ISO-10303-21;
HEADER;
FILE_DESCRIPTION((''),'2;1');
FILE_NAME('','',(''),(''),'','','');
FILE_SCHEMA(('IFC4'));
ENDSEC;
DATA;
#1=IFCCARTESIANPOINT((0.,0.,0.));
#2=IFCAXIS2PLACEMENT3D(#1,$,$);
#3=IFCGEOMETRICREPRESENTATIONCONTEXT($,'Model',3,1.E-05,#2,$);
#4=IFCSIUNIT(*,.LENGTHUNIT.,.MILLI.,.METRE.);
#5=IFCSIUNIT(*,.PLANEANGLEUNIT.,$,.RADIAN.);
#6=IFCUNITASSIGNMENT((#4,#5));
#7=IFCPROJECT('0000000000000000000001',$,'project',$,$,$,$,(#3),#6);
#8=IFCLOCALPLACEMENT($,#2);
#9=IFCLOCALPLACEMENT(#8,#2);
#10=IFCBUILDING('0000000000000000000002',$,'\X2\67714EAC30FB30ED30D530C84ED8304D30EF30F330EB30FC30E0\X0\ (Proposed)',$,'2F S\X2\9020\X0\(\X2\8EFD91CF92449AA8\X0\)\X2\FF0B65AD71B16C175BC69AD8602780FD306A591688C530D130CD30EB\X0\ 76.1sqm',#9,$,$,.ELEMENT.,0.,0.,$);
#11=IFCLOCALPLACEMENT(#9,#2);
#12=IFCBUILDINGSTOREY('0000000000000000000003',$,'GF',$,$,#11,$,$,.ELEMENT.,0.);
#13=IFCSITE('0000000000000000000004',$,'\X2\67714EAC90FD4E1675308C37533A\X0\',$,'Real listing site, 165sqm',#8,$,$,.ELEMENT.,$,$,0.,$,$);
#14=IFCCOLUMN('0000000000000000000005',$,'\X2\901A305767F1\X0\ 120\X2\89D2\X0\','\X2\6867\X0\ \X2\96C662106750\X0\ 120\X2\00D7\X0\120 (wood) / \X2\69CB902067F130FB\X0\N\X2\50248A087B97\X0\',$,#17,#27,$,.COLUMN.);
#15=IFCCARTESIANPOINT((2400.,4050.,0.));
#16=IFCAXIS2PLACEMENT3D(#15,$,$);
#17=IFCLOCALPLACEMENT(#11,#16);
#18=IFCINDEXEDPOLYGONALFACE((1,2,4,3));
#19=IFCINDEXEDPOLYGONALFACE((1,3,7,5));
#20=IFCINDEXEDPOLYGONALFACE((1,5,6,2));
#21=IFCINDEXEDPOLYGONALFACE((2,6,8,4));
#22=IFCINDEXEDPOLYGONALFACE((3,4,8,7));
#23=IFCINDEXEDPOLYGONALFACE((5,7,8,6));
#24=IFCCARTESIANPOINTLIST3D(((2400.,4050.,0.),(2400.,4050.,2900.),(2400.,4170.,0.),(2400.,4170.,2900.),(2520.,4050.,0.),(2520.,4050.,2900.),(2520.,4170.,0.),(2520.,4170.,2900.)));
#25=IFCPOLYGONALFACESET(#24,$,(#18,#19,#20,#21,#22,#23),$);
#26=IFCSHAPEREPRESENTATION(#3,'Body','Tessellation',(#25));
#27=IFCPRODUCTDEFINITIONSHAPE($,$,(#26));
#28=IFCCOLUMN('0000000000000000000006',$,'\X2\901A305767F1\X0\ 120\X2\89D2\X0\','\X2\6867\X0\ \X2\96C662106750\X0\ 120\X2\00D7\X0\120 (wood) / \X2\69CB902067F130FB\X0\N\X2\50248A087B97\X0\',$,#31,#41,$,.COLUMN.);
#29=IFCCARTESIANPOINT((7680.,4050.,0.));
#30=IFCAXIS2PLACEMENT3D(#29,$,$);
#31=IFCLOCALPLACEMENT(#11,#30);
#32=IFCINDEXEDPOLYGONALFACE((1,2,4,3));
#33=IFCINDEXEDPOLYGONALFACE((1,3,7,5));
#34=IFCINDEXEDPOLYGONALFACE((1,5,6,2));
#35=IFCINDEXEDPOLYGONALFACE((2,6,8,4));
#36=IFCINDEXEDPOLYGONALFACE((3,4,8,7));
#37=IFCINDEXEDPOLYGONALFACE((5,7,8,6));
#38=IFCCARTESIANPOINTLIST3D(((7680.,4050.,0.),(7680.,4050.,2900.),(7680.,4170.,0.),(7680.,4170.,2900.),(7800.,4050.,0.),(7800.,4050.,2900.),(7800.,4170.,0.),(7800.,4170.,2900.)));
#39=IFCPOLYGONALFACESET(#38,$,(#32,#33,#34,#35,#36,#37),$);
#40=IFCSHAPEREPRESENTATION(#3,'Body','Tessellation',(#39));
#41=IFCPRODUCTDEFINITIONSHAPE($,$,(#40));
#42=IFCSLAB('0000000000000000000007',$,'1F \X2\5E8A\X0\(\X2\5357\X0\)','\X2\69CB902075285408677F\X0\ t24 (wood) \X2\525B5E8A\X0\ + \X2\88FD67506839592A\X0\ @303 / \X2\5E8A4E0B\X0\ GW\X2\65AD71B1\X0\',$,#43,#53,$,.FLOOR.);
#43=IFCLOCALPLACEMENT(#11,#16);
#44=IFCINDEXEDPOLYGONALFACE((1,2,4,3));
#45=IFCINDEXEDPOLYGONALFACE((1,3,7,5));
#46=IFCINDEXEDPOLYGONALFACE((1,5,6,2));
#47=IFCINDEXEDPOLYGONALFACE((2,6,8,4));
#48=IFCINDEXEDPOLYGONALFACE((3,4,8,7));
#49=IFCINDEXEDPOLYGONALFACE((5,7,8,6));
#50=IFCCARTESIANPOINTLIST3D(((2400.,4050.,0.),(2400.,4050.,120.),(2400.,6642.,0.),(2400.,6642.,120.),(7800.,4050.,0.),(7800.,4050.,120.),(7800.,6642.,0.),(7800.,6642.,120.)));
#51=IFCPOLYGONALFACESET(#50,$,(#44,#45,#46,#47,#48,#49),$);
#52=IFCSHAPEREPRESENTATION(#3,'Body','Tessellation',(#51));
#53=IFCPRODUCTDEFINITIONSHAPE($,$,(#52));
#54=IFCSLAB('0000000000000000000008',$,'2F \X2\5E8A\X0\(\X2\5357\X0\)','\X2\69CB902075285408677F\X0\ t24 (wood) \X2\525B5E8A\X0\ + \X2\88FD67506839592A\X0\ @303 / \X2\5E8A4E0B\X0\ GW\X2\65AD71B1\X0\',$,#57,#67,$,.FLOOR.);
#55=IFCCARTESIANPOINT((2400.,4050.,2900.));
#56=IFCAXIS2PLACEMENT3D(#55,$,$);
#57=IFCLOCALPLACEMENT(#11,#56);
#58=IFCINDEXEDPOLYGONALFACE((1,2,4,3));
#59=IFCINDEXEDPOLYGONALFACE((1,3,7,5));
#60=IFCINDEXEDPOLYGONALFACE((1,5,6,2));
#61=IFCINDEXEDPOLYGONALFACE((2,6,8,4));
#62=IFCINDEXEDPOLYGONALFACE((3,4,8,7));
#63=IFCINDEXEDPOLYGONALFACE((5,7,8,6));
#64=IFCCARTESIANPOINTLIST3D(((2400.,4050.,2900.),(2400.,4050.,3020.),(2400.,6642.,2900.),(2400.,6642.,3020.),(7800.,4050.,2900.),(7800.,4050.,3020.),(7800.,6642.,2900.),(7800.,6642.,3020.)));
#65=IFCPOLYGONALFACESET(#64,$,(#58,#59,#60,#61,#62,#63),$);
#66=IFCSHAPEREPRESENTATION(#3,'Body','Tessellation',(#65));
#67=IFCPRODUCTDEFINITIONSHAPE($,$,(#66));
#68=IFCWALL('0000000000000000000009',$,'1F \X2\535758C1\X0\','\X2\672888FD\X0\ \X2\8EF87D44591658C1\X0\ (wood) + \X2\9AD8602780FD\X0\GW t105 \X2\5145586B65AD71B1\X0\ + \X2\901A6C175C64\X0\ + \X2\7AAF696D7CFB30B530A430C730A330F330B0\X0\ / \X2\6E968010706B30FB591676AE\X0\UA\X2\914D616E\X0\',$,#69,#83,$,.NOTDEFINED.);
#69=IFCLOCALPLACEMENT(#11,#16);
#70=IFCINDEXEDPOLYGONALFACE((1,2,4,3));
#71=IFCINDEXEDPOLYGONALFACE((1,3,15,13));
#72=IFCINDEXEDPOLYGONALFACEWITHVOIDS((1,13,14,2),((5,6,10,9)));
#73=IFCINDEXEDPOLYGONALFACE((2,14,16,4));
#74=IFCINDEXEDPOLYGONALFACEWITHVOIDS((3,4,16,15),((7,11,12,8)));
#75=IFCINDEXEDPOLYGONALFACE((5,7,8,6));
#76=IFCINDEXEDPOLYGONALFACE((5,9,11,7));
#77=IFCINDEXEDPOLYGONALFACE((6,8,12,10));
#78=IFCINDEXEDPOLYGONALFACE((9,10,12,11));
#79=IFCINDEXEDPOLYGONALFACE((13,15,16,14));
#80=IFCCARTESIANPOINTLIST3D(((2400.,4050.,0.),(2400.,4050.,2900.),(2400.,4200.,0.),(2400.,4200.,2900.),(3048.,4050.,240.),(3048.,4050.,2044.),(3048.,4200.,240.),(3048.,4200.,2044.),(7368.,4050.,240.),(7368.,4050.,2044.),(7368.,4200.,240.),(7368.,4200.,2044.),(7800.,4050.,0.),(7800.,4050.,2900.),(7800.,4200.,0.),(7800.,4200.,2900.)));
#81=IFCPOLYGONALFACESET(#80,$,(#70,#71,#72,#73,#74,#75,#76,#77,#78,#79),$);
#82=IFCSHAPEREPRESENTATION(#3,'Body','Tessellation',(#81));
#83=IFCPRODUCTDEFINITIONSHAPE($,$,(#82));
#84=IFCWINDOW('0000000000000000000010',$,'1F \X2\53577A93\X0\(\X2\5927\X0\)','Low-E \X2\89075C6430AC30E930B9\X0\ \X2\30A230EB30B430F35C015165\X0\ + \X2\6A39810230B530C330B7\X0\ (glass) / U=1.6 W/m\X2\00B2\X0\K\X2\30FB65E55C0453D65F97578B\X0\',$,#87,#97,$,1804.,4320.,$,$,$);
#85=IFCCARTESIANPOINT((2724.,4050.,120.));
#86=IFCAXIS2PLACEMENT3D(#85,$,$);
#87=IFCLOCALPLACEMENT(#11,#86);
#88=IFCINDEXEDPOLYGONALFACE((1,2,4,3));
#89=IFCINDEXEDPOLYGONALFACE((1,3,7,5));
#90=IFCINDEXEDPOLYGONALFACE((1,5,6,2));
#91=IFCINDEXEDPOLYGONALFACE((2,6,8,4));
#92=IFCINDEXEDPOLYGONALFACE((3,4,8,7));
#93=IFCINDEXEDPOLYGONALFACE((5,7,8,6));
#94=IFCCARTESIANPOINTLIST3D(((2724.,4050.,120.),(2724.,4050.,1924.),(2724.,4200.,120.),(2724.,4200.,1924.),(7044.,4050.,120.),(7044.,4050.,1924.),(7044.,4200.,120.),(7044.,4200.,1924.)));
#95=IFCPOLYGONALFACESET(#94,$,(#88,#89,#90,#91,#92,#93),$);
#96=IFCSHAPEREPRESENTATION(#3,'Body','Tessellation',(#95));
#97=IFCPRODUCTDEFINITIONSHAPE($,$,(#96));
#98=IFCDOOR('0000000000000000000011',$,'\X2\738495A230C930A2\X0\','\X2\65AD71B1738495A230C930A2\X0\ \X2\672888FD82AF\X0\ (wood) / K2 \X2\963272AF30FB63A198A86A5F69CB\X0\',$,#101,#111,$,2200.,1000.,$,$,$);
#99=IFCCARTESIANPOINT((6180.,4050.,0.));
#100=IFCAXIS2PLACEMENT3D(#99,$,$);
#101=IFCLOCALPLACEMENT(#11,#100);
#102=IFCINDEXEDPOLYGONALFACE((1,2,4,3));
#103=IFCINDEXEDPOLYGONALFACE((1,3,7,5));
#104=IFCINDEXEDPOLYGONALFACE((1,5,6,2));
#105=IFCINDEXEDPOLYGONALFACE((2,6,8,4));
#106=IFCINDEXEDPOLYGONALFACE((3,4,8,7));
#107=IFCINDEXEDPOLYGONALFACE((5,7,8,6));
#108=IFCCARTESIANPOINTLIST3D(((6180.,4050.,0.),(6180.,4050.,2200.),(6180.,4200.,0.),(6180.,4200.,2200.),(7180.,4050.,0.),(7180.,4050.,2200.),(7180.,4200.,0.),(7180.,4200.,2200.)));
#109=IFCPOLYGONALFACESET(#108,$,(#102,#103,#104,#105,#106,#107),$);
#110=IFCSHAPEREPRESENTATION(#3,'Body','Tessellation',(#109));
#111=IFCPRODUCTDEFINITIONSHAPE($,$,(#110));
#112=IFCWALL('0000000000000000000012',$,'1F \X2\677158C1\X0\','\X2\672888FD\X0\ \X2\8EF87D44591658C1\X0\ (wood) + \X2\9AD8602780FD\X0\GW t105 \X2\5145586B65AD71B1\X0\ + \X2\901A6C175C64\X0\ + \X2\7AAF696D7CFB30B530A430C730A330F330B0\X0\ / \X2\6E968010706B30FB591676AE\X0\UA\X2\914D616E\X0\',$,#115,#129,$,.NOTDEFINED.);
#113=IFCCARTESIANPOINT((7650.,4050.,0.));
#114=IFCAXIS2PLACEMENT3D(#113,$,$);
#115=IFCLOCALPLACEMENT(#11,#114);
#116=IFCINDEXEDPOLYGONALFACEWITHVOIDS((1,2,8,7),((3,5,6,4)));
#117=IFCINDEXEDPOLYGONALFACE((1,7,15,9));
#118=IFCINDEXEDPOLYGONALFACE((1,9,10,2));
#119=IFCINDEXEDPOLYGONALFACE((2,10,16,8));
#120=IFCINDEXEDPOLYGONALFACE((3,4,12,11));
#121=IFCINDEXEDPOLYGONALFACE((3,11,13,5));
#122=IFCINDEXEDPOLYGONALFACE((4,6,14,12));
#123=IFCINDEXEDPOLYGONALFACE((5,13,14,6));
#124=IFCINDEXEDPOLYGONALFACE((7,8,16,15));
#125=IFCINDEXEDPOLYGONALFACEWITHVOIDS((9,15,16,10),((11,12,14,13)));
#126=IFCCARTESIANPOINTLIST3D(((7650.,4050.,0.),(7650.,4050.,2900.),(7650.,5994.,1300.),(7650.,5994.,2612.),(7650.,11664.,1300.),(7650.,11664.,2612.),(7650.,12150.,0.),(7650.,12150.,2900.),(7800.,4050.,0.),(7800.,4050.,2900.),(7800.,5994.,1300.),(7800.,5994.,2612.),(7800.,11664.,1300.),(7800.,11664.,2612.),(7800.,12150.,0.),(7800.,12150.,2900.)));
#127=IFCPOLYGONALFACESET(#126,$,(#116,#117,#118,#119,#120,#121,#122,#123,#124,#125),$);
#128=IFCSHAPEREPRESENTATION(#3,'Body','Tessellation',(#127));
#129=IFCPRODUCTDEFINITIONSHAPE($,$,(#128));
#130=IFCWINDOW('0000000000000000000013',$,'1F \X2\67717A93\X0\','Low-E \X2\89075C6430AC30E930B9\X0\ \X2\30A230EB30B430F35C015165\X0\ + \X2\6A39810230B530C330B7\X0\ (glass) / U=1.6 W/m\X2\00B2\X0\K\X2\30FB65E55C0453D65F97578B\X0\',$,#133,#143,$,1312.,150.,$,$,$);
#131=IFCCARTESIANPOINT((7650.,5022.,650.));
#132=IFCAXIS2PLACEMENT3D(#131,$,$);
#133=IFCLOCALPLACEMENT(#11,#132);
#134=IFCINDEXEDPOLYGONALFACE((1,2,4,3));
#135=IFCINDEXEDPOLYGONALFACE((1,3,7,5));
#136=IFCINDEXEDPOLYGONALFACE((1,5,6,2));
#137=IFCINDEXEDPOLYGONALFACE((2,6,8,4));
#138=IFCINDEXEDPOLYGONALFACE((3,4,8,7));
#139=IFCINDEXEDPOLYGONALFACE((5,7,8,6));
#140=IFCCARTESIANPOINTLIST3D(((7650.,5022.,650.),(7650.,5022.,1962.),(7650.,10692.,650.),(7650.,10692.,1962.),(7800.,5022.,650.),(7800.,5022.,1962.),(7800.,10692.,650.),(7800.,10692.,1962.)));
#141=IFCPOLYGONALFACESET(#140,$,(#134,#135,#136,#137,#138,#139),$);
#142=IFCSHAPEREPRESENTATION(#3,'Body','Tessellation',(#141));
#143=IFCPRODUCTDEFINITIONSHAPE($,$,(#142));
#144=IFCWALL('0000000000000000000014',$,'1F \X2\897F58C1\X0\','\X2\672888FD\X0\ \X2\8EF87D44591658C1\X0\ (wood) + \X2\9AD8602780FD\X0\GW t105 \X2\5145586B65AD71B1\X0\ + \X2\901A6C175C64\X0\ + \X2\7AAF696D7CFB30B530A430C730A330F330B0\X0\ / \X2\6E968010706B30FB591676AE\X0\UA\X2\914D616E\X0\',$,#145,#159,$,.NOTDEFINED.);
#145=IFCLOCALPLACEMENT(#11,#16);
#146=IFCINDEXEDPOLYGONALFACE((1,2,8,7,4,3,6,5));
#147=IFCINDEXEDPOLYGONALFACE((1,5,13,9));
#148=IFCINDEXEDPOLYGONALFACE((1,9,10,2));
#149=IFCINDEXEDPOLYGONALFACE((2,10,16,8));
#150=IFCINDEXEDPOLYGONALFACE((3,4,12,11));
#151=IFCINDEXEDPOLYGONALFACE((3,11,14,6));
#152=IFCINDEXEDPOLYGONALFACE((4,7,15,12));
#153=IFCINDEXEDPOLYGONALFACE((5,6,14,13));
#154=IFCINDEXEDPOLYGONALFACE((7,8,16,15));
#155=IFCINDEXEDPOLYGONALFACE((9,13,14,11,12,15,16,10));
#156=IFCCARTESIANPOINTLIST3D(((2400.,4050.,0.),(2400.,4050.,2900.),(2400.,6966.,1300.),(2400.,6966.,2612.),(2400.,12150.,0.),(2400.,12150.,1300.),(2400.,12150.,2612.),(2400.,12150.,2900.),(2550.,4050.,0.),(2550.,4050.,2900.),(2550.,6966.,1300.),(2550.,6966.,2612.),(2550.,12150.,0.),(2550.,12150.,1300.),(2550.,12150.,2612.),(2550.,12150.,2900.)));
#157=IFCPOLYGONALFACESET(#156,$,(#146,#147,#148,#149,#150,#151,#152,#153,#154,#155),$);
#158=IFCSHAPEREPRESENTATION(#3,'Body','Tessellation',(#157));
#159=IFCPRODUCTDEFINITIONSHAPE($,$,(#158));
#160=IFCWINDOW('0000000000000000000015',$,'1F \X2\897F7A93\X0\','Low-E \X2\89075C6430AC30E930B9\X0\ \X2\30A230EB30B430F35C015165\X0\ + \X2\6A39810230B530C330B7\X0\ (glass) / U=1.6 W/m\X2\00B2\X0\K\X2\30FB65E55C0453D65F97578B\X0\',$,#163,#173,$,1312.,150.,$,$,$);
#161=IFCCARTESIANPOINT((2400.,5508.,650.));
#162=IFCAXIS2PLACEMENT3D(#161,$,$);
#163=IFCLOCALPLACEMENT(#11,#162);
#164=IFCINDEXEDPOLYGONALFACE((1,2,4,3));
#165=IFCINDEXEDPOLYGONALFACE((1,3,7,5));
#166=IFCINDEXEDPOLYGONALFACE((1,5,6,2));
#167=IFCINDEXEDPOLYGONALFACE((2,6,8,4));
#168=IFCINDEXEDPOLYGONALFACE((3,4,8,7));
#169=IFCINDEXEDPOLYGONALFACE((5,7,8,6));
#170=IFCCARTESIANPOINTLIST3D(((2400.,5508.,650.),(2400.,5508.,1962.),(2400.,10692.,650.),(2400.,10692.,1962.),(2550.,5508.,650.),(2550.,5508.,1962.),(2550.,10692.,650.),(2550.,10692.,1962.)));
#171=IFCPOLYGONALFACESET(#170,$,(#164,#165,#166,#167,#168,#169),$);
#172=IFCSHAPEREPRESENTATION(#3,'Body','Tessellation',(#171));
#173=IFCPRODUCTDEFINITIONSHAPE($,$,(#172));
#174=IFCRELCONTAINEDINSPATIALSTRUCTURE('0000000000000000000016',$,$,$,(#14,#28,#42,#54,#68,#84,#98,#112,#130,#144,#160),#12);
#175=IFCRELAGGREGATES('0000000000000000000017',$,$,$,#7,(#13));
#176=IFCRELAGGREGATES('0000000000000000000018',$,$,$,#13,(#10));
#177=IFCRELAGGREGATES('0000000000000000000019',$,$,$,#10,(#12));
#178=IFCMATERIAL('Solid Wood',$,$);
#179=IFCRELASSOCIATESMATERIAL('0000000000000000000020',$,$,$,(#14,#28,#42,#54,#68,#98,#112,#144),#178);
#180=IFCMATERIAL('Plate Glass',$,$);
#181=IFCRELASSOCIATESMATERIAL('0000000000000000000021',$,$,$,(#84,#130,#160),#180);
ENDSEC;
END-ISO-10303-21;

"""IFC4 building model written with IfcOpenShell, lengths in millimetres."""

from ifc_helpers import new_model, si_unit, frame, frame_2d, origin, place, context, project, spatial, rectangle, extrude, material, element, fill, save


model = new_model("IFC4")

# Units and contexts
model_context = context("Model", 3, precision=1e-05, world=origin())
ifc_project = project(units=[si_unit("LENGTHUNIT", "METRE", prefix="MILLI"), si_unit("PLANEANGLEUNIT", "RADIAN")], contexts=[model_context])

# Site, building, storey
site_placement = place(None, origin())
site = spatial("IfcSite", under=ifc_project, at=site_placement, Name="東京都世田谷区", ObjectType="Real listing site, 165sqm", CompositionType="ELEMENT", RefElevation=0.0)
building_placement = place(site_placement, origin())
building = spatial("IfcBuilding", under=site, at=building_placement, Name="東京・ロフト付きワンルーム (Proposed)", ObjectType="2F S造(軽量鉄骨)＋断熱気密高性能な外装パネル 76.1sqm", CompositionType="ELEMENT", ElevationOfRefHeight=0.0, ElevationOfTerrain=0.0)
storey_placement = place(building_placement, origin())
storey = spatial("IfcBuildingStorey", under=building, at=storey_placement, Name="GF", CompositionType="ELEMENT", Elevation=0.0)

# Columns
ifc_material_1 = material(Name="Solid Wood")
column_1_placement = place(storey_placement, frame((2400.0, 4050.0, 0.0)))
element("IfcColumn", 1, at=column_1_placement, inside=storey, material=ifc_material_1, Name="通し柱 120角", Description="桧 集成材 120×120 (wood) / 構造柱・N値計算", PredefinedType="COLUMN", context=model_context, shape_type="SweptSolid", body=[
    extrude(rectangle(XDim=120.0, YDim=120.0, at=frame_2d((60.0, 60.0))), frame((2400.0, 4050.0, 0.0)), (0.0, 0.0, 1.0), 2900.0),
])
column_2_placement = place(storey_placement, frame((7680.0, 4050.0, 0.0)))
element("IfcColumn", 2, at=column_2_placement, inside=storey, material=ifc_material_1, Name="通し柱 120角", Description="桧 集成材 120×120 (wood) / 構造柱・N値計算", PredefinedType="COLUMN", context=model_context, shape_type="SweptSolid", body=[
    extrude(rectangle(XDim=120.0, YDim=120.0, at=frame_2d((60.0, 60.0))), frame((7680.0, 4050.0, 0.0)), (0.0, 0.0, 1.0), 2900.0),
])

# Slabs
slab_1_placement = place(storey_placement, frame((2400.0, 4050.0, 0.0)))
element("IfcSlab", 3, at=slab_1_placement, inside=storey, material=ifc_material_1, Name="1F 床(南)", Description="構造用合板 t24 (wood) 剛床 + 製材根太 @303 / 床下 GW断熱", PredefinedType="FLOOR", context=model_context, shape_type="SweptSolid", body=[
    extrude(rectangle(XDim=5400.0, YDim=2592.0, at=frame_2d((2700.0, 1296.0))), frame((2400.0, 4050.0, 0.0)), (0.0, 0.0, 1.0), 120.0),
])
slab_2_placement = place(storey_placement, frame((2400.0, 4050.0, 2900.0)))
element("IfcSlab", 4, at=slab_2_placement, inside=storey, material=ifc_material_1, Name="2F 床(南)", Description="構造用合板 t24 (wood) 剛床 + 製材根太 @303 / 床下 GW断熱", PredefinedType="FLOOR", context=model_context, shape_type="SweptSolid", body=[
    extrude(rectangle(XDim=5400.0, YDim=2592.0, at=frame_2d((2700.0, 1296.0))), frame((2400.0, 4050.0, 2900.0)), (0.0, 0.0, 1.0), 120.0),
])

# Wall, openings, window, door
wall_1_placement = place(storey_placement, frame((2400.0, 4050.0, 0.0)))
wall_1 = element("IfcWall", 5, at=wall_1_placement, inside=storey, material=ifc_material_1, Name="1F 南壁", Description="木製 軸組外壁 (wood) + 高性能GW t105 充填断熱 + 通気層 + 窯業系サイディング / 準耐火・外皮UA配慮", PredefinedType="NOTDEFINED", context=model_context, shape_type="SweptSolid", body=[
    extrude(rectangle(XDim=5400.0, YDim=150.0, at=frame_2d((2700.0, 75.0))), frame((2400.0, 4050.0, 0.0)), (0.0, 0.0, 1.0), 2900.0),
])
opening_1_placement = place(storey_placement, frame((2724.0, 4050.0, 120.0)))
opening_1 = element("IfcOpeningElement", 6, at=opening_1_placement, cuts=wall_1, PredefinedType="NOTDEFINED", context=model_context, shape_type="SweptSolid", body=[
    extrude(rectangle(XDim=4320.0, YDim=150.0, at=frame_2d((2160.0, 75.0))), frame((2724.0, 4050.0, 120.0)), (0.0, 0.0, 1.0), 1804.0),
])
opening_2_placement = place(storey_placement, frame((6180.0, 4050.0, 0.0)))
opening_2 = element("IfcOpeningElement", 7, at=opening_2_placement, cuts=wall_1, PredefinedType="NOTDEFINED", context=model_context, shape_type="SweptSolid", body=[
    extrude(rectangle(XDim=1000.0, YDim=150.0, at=frame_2d((500.0, 75.0))), frame((6180.0, 4050.0, 0.0)), (0.0, 0.0, 1.0), 2200.0),
])
ifc_material_2 = material(Name="Plate Glass")
window_1_placement = place(storey_placement, frame((2724.0, 4050.0, 120.0)))
window_1 = element("IfcWindow", 8, at=window_1_placement, inside=storey, material=ifc_material_2, Name="1F 南窓(大)", Description="Low-E 複層ガラス アルゴン封入 + 樹脂サッシ (glass) / U=1.6 W/m²K・日射取得型", OverallHeight=1804.0, OverallWidth=4320.0, context=model_context, shape_type="SweptSolid", body=[
    extrude(rectangle(XDim=4320.0, YDim=150.0, at=frame_2d((2160.0, 75.0))), frame((2724.0, 4050.0, 120.0)), (0.0, 0.0, 1.0), 1804.0),
])
fill(opening_1, window_1)
door_placement = place(storey_placement, frame((6180.0, 4050.0, 0.0)))
door = element("IfcDoor", 9, at=door_placement, inside=storey, material=ifc_material_1, Name="玄関ドア", Description="断熱玄関ドア 木製芯 (wood) / K2 防犯・採風機構", OverallHeight=2200.0, OverallWidth=1000.0, context=model_context, shape_type="SweptSolid", body=[
    extrude(rectangle(XDim=1000.0, YDim=150.0, at=frame_2d((500.0, 75.0))), frame((6180.0, 4050.0, 0.0)), (0.0, 0.0, 1.0), 2200.0),
])
fill(opening_2, door)

# Walls, openings, windows
wall_2_placement = place(storey_placement, frame((7650.0, 4050.0, 0.0)))
wall_2 = element("IfcWall", 10, at=wall_2_placement, inside=storey, material=ifc_material_1, Name="1F 東壁", Description="木製 軸組外壁 (wood) + 高性能GW t105 充填断熱 + 通気層 + 窯業系サイディング / 準耐火・外皮UA配慮", PredefinedType="NOTDEFINED", context=model_context, shape_type="SweptSolid", body=[
    extrude(rectangle(XDim=150.0, YDim=8100.0, at=frame_2d((75.0, 4050.0))), frame((7650.0, 4050.0, 0.0)), (0.0, 0.0, 1.0), 2900.0),
])
opening_3_placement = place(storey_placement, frame((7650.0, 5022.0, 650.0)))
opening_3 = element("IfcOpeningElement", 11, at=opening_3_placement, cuts=wall_2, PredefinedType="NOTDEFINED", context=model_context, shape_type="SweptSolid", body=[
    extrude(rectangle(XDim=150.0, YDim=5670.0, at=frame_2d((75.0, 2835.0))), frame((7650.0, 5022.0, 650.0)), (0.0, 0.0, 1.0), 1312.0),
])
window_2_placement = place(storey_placement, frame((7650.0, 5022.0, 650.0)))
window_2 = element("IfcWindow", 12, at=window_2_placement, inside=storey, material=ifc_material_2, Name="1F 東窓", Description="Low-E 複層ガラス アルゴン封入 + 樹脂サッシ (glass) / U=1.6 W/m²K・日射取得型", OverallHeight=1312.0, OverallWidth=150.0, context=model_context, shape_type="SweptSolid", body=[
    extrude(rectangle(XDim=150.0, YDim=5670.0, at=frame_2d((75.0, 2835.0))), frame((7650.0, 5022.0, 650.0)), (0.0, 0.0, 1.0), 1312.0),
])
fill(opening_3, window_2)
wall_3_placement = place(storey_placement, frame((2400.0, 4050.0, 0.0)))
wall_3 = element("IfcWall", 13, at=wall_3_placement, inside=storey, material=ifc_material_1, Name="1F 西壁", Description="木製 軸組外壁 (wood) + 高性能GW t105 充填断熱 + 通気層 + 窯業系サイディング / 準耐火・外皮UA配慮", PredefinedType="NOTDEFINED", context=model_context, shape_type="SweptSolid", body=[
    extrude(rectangle(XDim=150.0, YDim=8100.0, at=frame_2d((75.0, 4050.0))), frame((2400.0, 4050.0, 0.0)), (0.0, 0.0, 1.0), 2900.0),
])
opening_4_placement = place(storey_placement, frame((2400.0, 5508.0, 650.0)))
opening_4 = element("IfcOpeningElement", 14, at=opening_4_placement, cuts=wall_3, PredefinedType="NOTDEFINED", context=model_context, shape_type="SweptSolid", body=[
    extrude(rectangle(XDim=150.0, YDim=5184.0, at=frame_2d((75.0, 2592.0))), frame((2400.0, 5508.0, 650.0)), (0.0, 0.0, 1.0), 1312.0),
])
window_3_placement = place(storey_placement, frame((2400.0, 5508.0, 650.0)))
window_3 = element("IfcWindow", 15, at=window_3_placement, inside=storey, material=ifc_material_2, Name="1F 西窓", Description="Low-E 複層ガラス アルゴン封入 + 樹脂サッシ (glass) / U=1.6 W/m²K・日射取得型", OverallHeight=1312.0, OverallWidth=150.0, context=model_context, shape_type="SweptSolid", body=[
    extrude(rectangle(XDim=150.0, YDim=5184.0, at=frame_2d((75.0, 2592.0))), frame((2400.0, 5508.0, 650.0)), (0.0, 0.0, 1.0), 1312.0),
])
fill(opening_4, window_3)

save(model, "model.ifc")
